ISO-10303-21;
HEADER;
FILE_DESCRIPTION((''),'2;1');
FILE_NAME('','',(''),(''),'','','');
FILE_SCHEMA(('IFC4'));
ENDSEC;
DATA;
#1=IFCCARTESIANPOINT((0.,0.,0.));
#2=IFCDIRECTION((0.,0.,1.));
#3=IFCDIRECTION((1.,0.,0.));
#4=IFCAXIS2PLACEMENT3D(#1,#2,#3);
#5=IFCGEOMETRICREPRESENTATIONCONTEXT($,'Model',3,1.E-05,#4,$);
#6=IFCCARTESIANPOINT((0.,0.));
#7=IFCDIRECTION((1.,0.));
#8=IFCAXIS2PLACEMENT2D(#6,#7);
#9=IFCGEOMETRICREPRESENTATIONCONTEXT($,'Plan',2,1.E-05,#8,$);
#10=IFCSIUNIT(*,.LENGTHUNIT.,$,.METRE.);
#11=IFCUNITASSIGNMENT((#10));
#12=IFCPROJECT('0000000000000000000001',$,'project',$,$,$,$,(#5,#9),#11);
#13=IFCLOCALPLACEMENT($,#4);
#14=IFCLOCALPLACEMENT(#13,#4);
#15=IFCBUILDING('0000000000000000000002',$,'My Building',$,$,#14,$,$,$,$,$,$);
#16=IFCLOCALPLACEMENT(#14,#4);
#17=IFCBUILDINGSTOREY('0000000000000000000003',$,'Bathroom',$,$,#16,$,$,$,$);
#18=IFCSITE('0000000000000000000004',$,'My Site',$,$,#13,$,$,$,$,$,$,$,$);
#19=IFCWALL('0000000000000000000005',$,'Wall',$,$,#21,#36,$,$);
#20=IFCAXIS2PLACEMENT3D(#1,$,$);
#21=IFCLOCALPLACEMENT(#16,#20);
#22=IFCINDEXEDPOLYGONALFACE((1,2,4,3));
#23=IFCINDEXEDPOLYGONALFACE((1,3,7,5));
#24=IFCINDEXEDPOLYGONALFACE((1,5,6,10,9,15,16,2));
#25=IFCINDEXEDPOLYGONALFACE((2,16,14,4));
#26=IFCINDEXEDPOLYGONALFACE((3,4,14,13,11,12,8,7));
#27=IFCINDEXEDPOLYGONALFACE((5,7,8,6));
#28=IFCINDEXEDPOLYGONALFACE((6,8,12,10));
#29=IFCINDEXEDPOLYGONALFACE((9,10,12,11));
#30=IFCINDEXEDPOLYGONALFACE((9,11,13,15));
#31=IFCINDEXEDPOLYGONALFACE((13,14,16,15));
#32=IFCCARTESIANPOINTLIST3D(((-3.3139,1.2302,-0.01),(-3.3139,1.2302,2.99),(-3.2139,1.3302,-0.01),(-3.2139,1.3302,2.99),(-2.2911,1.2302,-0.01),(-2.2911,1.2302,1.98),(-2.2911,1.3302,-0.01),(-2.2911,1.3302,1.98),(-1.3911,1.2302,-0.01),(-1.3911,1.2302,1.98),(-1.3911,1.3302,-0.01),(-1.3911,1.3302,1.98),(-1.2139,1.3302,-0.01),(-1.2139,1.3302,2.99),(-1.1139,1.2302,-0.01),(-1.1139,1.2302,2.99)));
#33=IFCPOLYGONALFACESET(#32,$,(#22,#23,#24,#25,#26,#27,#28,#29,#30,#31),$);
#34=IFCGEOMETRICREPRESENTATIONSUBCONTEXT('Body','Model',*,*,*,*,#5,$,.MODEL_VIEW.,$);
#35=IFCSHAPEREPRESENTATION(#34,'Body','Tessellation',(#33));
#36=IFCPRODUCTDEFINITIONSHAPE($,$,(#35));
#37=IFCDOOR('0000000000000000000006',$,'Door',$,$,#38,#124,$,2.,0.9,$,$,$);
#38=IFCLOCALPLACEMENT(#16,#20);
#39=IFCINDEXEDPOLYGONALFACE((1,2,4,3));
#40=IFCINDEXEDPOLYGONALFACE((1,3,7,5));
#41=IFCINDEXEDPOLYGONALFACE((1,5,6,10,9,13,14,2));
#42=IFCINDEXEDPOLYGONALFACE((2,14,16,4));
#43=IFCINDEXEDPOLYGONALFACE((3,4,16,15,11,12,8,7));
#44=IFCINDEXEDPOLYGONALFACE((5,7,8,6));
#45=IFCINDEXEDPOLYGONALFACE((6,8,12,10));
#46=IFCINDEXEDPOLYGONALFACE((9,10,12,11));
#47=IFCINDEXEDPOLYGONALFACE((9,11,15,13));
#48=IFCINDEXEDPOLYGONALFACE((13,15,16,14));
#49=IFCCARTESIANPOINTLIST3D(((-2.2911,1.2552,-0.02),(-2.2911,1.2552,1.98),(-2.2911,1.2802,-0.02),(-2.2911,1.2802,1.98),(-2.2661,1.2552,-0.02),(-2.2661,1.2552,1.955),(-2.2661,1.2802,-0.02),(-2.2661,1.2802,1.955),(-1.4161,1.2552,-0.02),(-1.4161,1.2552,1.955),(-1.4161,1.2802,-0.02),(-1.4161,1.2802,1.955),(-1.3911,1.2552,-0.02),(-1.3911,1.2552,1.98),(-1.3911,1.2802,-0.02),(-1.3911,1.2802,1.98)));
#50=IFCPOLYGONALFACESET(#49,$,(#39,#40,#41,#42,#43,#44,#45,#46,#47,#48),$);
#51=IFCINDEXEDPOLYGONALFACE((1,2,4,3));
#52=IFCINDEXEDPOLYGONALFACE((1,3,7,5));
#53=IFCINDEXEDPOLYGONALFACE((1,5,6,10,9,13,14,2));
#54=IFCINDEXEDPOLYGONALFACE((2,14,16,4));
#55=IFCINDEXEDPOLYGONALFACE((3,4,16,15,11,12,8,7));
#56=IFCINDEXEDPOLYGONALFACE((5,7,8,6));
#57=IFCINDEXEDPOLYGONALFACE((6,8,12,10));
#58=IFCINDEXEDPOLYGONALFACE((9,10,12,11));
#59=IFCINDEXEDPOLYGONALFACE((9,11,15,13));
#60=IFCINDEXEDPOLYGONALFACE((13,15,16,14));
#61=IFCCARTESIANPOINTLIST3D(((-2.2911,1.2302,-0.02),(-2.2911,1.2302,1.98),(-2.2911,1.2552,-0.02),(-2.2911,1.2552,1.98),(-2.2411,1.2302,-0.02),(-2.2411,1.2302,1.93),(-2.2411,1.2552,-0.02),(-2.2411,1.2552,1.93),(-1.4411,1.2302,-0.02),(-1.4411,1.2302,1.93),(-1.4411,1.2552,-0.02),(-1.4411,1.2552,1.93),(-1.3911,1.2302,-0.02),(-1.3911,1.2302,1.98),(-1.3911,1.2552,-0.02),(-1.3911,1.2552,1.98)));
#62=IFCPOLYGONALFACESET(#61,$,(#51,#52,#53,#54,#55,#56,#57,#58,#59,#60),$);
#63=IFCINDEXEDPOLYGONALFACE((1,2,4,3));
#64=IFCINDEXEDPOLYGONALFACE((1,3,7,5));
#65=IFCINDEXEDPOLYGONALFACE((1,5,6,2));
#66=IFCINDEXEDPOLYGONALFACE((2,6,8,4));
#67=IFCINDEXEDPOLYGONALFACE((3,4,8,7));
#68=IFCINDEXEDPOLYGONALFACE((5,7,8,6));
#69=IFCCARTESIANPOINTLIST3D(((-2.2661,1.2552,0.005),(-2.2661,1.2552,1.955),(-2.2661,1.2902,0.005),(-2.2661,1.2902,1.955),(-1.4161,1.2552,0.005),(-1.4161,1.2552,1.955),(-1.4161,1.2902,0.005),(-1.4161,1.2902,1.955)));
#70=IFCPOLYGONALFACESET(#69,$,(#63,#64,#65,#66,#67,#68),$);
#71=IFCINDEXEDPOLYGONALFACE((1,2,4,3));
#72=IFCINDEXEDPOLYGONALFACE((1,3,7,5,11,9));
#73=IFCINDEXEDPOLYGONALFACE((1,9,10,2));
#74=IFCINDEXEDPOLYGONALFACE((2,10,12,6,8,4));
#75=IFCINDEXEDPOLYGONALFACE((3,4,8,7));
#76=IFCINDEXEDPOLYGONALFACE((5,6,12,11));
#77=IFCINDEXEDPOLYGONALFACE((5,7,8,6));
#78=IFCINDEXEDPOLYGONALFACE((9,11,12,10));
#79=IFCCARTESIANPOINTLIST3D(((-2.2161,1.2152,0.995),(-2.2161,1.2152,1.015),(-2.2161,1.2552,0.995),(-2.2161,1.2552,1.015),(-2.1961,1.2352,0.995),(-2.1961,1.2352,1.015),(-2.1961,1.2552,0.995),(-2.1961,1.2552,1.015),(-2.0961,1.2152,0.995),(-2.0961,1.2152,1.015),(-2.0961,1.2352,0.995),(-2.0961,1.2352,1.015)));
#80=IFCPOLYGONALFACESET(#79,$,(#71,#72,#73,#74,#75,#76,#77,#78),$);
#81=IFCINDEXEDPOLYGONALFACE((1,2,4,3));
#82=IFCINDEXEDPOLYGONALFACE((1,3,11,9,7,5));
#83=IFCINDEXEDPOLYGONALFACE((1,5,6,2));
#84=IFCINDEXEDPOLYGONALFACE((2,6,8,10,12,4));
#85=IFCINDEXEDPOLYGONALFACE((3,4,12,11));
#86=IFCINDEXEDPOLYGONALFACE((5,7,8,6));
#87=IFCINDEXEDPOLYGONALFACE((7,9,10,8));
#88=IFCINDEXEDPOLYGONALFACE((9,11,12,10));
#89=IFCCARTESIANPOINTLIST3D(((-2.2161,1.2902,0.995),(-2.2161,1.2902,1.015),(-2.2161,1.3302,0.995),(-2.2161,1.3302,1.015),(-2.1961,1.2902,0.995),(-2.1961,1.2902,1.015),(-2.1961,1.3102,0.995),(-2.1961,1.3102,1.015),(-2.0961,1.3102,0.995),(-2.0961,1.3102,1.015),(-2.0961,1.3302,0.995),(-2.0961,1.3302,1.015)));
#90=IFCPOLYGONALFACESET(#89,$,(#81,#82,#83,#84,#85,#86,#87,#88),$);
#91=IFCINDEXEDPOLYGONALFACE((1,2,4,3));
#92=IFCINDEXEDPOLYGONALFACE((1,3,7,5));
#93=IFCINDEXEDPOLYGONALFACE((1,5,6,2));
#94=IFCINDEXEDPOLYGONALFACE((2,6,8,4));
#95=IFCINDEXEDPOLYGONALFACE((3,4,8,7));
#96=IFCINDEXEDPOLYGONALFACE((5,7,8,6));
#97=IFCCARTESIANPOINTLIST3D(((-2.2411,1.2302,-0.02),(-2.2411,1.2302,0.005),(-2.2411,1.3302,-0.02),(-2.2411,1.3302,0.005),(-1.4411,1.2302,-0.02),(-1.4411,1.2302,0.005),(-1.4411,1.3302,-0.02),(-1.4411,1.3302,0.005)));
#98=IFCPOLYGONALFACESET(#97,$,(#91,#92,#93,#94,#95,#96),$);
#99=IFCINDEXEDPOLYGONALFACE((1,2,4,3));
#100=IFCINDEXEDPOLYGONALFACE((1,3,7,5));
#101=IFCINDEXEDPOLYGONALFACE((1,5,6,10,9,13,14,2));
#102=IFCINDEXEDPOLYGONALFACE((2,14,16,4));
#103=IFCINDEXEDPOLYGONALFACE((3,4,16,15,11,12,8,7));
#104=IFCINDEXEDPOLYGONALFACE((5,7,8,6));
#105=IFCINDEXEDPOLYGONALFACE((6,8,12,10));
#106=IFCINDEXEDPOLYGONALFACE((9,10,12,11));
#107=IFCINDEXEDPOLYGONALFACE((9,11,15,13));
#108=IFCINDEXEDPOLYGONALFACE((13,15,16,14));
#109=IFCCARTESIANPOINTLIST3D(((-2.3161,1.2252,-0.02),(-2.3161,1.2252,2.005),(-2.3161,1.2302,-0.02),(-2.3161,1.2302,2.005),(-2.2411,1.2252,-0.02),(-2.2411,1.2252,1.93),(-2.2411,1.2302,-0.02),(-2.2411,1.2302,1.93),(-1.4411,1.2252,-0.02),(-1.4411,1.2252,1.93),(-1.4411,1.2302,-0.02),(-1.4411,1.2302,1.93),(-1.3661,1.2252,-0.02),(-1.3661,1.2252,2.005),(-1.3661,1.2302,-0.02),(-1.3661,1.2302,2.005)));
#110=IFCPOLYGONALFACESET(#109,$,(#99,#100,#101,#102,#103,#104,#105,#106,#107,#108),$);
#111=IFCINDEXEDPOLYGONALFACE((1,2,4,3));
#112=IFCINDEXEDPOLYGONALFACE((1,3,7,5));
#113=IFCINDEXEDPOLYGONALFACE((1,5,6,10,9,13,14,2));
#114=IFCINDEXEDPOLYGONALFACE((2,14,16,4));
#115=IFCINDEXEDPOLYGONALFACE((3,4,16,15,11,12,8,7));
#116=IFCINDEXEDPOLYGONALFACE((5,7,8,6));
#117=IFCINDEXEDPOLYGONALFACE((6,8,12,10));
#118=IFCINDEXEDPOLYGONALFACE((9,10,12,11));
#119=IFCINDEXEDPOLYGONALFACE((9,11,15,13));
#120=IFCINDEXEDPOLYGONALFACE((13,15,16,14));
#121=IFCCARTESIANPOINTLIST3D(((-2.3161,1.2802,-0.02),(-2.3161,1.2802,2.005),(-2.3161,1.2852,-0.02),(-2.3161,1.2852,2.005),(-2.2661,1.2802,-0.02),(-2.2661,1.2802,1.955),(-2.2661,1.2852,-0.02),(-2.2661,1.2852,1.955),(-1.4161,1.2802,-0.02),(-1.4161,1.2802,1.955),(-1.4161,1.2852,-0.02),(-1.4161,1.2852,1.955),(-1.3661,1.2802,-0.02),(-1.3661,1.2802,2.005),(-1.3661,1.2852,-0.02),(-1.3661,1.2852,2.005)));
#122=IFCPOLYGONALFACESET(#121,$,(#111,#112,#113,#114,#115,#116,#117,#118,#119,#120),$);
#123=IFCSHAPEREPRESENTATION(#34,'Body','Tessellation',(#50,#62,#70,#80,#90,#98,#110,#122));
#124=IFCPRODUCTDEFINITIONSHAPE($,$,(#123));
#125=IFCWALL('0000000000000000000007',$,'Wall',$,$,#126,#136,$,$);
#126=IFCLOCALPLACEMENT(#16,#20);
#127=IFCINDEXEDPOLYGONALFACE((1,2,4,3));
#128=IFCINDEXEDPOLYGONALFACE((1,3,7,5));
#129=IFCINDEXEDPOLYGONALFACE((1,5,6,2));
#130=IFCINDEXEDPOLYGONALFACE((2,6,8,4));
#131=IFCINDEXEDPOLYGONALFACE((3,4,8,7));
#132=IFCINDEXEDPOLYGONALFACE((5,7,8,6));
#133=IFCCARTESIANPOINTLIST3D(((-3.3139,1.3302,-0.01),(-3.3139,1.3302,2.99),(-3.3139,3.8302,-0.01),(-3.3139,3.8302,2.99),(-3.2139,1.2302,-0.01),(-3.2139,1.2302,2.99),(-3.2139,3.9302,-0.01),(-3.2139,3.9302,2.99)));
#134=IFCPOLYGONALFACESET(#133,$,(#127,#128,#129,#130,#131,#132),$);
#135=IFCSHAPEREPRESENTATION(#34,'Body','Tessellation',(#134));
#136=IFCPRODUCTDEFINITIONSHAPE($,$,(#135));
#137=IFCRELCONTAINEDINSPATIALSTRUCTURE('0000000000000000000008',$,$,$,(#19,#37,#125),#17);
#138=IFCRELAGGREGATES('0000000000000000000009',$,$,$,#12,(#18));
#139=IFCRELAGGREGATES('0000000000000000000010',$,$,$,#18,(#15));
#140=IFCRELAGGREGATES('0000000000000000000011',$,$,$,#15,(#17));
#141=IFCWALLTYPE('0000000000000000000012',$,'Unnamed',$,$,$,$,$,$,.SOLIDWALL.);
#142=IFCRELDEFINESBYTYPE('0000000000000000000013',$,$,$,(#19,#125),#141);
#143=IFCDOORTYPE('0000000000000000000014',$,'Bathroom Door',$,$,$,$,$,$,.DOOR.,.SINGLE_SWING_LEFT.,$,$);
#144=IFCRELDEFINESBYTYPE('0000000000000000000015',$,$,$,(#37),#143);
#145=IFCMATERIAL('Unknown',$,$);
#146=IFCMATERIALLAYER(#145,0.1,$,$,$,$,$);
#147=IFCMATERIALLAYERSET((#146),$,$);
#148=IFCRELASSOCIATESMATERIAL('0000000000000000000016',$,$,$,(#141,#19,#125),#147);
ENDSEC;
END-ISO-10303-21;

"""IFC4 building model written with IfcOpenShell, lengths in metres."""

from ifc_helpers import new_model, entity, si_unit, frame, origin_with_axes, origin_2d_with_axis, place, context, subcontext, project, spatial, line, indexed_curve, outline, extrude, shape, source, transform, mapped, material, layer, layer_set, layer_usage, type_object, type_shapes, element, fill, save


model = new_model("IFC4")

# Units and contexts
model_context = context("Model", 3, precision=1e-05, world=origin_with_axes())
plan_context = context("Plan", 2, precision=1e-05, world=origin_2d_with_axis())
body_context_1 = subcontext(model_context, "Body", "Model", "MODEL_VIEW")
body_context_2 = subcontext(plan_context, "Body", "Plan", "PLAN_VIEW")
ifc_project = project(units=[si_unit("LENGTHUNIT", "METRE")], contexts=[model_context, plan_context])

# Site, building, storey
site_placement = place(None, origin_with_axes())
site = spatial("IfcSite", under=ifc_project, at=site_placement, Name="My Site")
building_placement = place(site_placement, origin_with_axes())
building = spatial("IfcBuilding", under=site, at=building_placement, Name="My Building")
storey_placement = place(building_placement, origin_with_axes())
storey = spatial("IfcBuildingStorey", under=building, at=storey_placement, Name="Bathroom")

# Shared definitions
ifc_material = material(Name="Unknown")

# Shared definitions
ifc_layer_1 = layer(ifc_material, 0.1)
ifc_layer_set_1 = layer_set([ifc_layer_1])
wall_type = type_object("IfcWallType", Name="Unnamed", PredefinedType="SOLIDWALL", material=ifc_layer_set_1)

# Wall, opening, door
ifc_layer_usage_1 = layer_usage(ifc_layer_set_1, "AXIS2", "POSITIVE", 0.0)
wall_1_placement = place(storey_placement, frame((-1.2139, 1.3302, -0.01), z_axis=(0.0, 0.0, 1.0), x_axis=(-1.0, 0.0, 0.0)))
wall_1 = element("IfcWall", 1, at=wall_1_placement, inside=storey, type_object=wall_type, material=ifc_layer_usage_1, Name="Wall", context=body_context_1, shape_type="SweptSolid", body=[
    extrude(outline(indexed_curve([(0.0, 0.0), (-0.1, 0.1), (2.1, 0.1), (2.0, 0.0)], segments=[line(1, 2, 3, 4, 1)])), origin_with_axes(), (0.0, 0.0, 1.0), 3.0),
])
shared_shape_1 = source(origin_with_axes(), body_context_1, "Body", "SweptSolid", [
    extrude(outline(indexed_curve([(0.0, 0.0), (0.9, 0.0), (0.9, 2.0), (0.0, 2.0)], segments=[line(1, 2, 3, 4, 1)])), frame((0.0, -0.6, 0.0), z_axis=(0.0, -1.0, 0.0), x_axis=(1.0, 0.0, 0.0)), (0.0, 0.0, -1.0), 1.2),
])
opening_1_placement = place(wall_1_placement, frame((1.0772, 0.1, -0.01), z_axis=(0.0, 0.0, 1.0), x_axis=(-1.0, 0.0, 0.0)))
opening_1 = element("IfcOpeningElement", 2, at=opening_1_placement, cuts=wall_1, PredefinedType="OPENING", context=body_context_1, shape_type="MappedRepresentation", body=[
    mapped(shared_shape_1, transform((0.0, 0.0, 0.0), x_axis=(1.0, 0.0, 0.0), y_axis=(0.0, 1.0, 0.0), z_axis=(0.0, 0.0, 1.0), scale=1.0)),
])
door_type = type_object("IfcDoorType", Name="Bathroom Door", OperationType="SINGLE_SWING_LEFT", PredefinedType="DOOR")
shared_shape_2 = source(origin_with_axes(), body_context_1, "Body", "SweptSolid", [
    extrude(outline(indexed_curve([(0.0, 0.0), (0.0, 2.0), (0.9, 2.0), (0.9, 0.0), (0.875, 0.0), (0.875, 1.975), (0.025, 1.975), (0.025, 0.0)], segments=[line(1, 2, 3, 4, 5, 6, 7, 8, 1)])), frame((0.0, 0.025, 0.0), z_axis=(0.0, -1.0, 0.0), x_axis=(1.0, 0.0, 0.0)), (0.0, 0.0, -1.0), 0.025),
    extrude(outline(indexed_curve([(0.0, 0.0), (0.0, 2.0), (0.9, 2.0), (0.9, 0.0), (0.85, 0.0), (0.85, 1.95), (0.05, 1.95), (0.05, 0.0)], segments=[line(1, 2, 3, 4, 5, 6, 7, 8, 1)])), frame((0.0, 0.0, 0.0), z_axis=(0.0, -1.0, 0.0), x_axis=(1.0, 0.0, 0.0)), (0.0, 0.0, -1.0), 0.025),
    extrude(outline(indexed_curve([(0.0, 0.0), (0.85, 0.0), (0.85, 0.035), (0.0, 0.035)], segments=[line(1, 2, 3, 4, 1)])), frame((0.025, 0.025, 0.025), z_axis=(0.0, 0.0, 1.0), x_axis=(1.0, 0.0, 0.0)), (0.0, 0.0, 1.0), 1.95),
    extrude(outline(indexed_curve([(0.0, 0.0), (0.0, -0.04), (0.12, -0.04), (0.12, -0.02), (0.02, -0.02), (0.02, 0.0)], segments=[line(1, 2, 3, 4, 5, 6, 1)])), frame((0.075, 0.025, 1.015), z_axis=(0.0, 0.0, 1.0), x_axis=(1.0, 0.0, 0.0)), (0.0, 0.0, 1.0), 0.02),
    extrude(outline(indexed_curve([(0.0, 0.0), (0.0, 0.04), (0.12, 0.04), (0.12, 0.02), (0.02, 0.02), (0.02, 0.0)], segments=[line(1, 2, 3, 4, 5, 6, 1)])), frame((0.075, 0.06, 1.015), z_axis=(0.0, 0.0, 1.0), x_axis=(1.0, 0.0, 0.0)), (0.0, 0.0, 1.0), 0.02),
    extrude(outline(indexed_curve([(0.0, 0.0), (0.8, 0.0), (0.8, 0.1), (0.0, 0.1)], segments=[line(1, 2, 3, 4, 1)])), frame((0.05, 0.0, 0.0), z_axis=(0.0, 0.0, 1.0), x_axis=(1.0, 0.0, 0.0)), (0.0, 0.0, 1.0), 0.025),
    extrude(outline(indexed_curve([(0.0, 0.0), (0.0, 2.025), (0.95, 2.025), (0.95, 0.0), (0.875, 0.0), (0.875, 1.95), (0.075, 1.95), (0.075, 0.0)], segments=[line(1, 2, 3, 4, 5, 6, 7, 8, 1)])), frame((-0.025, -0.005, 0.0), z_axis=(0.0, -1.0, 0.0), x_axis=(1.0, 0.0, 0.0)), (0.0, 0.0, -1.0), 0.005),
    extrude(outline(indexed_curve([(0.0, 0.0), (0.0, 2.025), (0.95, 2.025), (0.95, 0.0), (0.9, 0.0), (0.9, 1.975), (0.05, 1.975), (0.05, 0.0)], segments=[line(1, 2, 3, 4, 5, 6, 7, 8, 1)])), frame((-0.025, 0.05, 0.0), z_axis=(0.0, -1.0, 0.0), x_axis=(1.0, 0.0, 0.0)), (0.0, 0.0, -1.0), 0.005),
])
shared_shape_3 = source(origin_with_axes(), body_context_2, "Body", "Curve2D", [
    entity("IfcIndexedPolyCurve", entity("IfcCartesianPointList2D", [[0.0, 0.0], [0.0, 0.05], [0.025, 0.05], [0.025, 0.025], [0.05, 0.025], [0.05, 0.0]]), [entity("IfcLineIndex", [1, 2, 3, 4, 5, 6, 1])]),
    entity("IfcIndexedPolyCurve", entity("IfcCartesianPointList2D", [[0.9, 0.0], [0.9, 0.05], [0.875, 0.05], [0.875, 0.025], [0.85, 0.025], [0.85, 0.0]]), [entity("IfcLineIndex", [1, 2, 3, 4, 5, 6, 1])]),
    entity("IfcTrimmedCurve", entity("IfcEllipse", entity("IfcAxis2Placement2D", entity("IfcCartesianPoint", [0.84, 0.05]), entity("IfcDirection", [1.0, 0.0])), 0.815, 0.85), [entity("IfcCartesianPoint", [0.84, 0.9])], [entity("IfcCartesianPoint", [0.025, 0.05])], True, "CARTESIAN"),
    entity("IfcIndexedPolyCurve", entity("IfcCartesianPointList2D", [[0.875, 0.05], [0.84, 0.05], [0.84, 0.9], [0.875, 0.9]]), [entity("IfcLineIndex", [1, 2, 3, 4, 1])]),
])
type_shapes(door_type, [shared_shape_2, shared_shape_3])
door_1_placement = place(opening_1_placement, frame((0.0, 0.0, 0.0), z_axis=(0.0, 0.0, 1.0), x_axis=(1.0, 0.0, 0.0)))
door_1 = element("IfcDoor", 3, at=door_1_placement, inside=storey, type_object=door_type, Name="Door", OverallHeight=2.0, OverallWidth=0.9, shapes=[
    shape(body_context_1, "Body", "MappedRepresentation", [mapped(shared_shape_2, transform((0.0, 0.0, 0.0), x_axis=(1.0, 0.0, 0.0), y_axis=(0.0, 1.0, 0.0), z_axis=(0.0, 0.0, 1.0), scale=1.0))]),
    shape(body_context_2, "Body", "MappedRepresentation", [mapped(shared_shape_3, transform((0.0, 0.0, 0.0), x_axis=(1.0, 0.0, 0.0), y_axis=(0.0, 1.0, 0.0), z_axis=(0.0, 0.0, 1.0), scale=1.0))]),
])
fill(opening_1, door_1)

# Wall
ifc_layer_usage_2 = layer_usage(ifc_layer_set_1, "AXIS2", "POSITIVE", 0.0)
wall_2_placement = place(storey_placement, frame((-3.2139, 1.2302, -0.01), z_axis=(0.0, 0.0, 1.0), x_axis=(0.0, 1.0, 0.0)))
element("IfcWall", 4, at=wall_2_placement, inside=storey, type_object=wall_type, material=ifc_layer_usage_2, Name="Wall", context=body_context_1, shape_type="SweptSolid", body=[
    extrude(outline(indexed_curve([(0.0, 0.0), (0.1, 0.1), (2.6, 0.1), (2.7, 0.0)], segments=[line(1, 2, 3, 4, 1)])), origin_with_axes(), (0.0, 0.0, 1.0), 3.0),
])

save(model, "model.ifc")
